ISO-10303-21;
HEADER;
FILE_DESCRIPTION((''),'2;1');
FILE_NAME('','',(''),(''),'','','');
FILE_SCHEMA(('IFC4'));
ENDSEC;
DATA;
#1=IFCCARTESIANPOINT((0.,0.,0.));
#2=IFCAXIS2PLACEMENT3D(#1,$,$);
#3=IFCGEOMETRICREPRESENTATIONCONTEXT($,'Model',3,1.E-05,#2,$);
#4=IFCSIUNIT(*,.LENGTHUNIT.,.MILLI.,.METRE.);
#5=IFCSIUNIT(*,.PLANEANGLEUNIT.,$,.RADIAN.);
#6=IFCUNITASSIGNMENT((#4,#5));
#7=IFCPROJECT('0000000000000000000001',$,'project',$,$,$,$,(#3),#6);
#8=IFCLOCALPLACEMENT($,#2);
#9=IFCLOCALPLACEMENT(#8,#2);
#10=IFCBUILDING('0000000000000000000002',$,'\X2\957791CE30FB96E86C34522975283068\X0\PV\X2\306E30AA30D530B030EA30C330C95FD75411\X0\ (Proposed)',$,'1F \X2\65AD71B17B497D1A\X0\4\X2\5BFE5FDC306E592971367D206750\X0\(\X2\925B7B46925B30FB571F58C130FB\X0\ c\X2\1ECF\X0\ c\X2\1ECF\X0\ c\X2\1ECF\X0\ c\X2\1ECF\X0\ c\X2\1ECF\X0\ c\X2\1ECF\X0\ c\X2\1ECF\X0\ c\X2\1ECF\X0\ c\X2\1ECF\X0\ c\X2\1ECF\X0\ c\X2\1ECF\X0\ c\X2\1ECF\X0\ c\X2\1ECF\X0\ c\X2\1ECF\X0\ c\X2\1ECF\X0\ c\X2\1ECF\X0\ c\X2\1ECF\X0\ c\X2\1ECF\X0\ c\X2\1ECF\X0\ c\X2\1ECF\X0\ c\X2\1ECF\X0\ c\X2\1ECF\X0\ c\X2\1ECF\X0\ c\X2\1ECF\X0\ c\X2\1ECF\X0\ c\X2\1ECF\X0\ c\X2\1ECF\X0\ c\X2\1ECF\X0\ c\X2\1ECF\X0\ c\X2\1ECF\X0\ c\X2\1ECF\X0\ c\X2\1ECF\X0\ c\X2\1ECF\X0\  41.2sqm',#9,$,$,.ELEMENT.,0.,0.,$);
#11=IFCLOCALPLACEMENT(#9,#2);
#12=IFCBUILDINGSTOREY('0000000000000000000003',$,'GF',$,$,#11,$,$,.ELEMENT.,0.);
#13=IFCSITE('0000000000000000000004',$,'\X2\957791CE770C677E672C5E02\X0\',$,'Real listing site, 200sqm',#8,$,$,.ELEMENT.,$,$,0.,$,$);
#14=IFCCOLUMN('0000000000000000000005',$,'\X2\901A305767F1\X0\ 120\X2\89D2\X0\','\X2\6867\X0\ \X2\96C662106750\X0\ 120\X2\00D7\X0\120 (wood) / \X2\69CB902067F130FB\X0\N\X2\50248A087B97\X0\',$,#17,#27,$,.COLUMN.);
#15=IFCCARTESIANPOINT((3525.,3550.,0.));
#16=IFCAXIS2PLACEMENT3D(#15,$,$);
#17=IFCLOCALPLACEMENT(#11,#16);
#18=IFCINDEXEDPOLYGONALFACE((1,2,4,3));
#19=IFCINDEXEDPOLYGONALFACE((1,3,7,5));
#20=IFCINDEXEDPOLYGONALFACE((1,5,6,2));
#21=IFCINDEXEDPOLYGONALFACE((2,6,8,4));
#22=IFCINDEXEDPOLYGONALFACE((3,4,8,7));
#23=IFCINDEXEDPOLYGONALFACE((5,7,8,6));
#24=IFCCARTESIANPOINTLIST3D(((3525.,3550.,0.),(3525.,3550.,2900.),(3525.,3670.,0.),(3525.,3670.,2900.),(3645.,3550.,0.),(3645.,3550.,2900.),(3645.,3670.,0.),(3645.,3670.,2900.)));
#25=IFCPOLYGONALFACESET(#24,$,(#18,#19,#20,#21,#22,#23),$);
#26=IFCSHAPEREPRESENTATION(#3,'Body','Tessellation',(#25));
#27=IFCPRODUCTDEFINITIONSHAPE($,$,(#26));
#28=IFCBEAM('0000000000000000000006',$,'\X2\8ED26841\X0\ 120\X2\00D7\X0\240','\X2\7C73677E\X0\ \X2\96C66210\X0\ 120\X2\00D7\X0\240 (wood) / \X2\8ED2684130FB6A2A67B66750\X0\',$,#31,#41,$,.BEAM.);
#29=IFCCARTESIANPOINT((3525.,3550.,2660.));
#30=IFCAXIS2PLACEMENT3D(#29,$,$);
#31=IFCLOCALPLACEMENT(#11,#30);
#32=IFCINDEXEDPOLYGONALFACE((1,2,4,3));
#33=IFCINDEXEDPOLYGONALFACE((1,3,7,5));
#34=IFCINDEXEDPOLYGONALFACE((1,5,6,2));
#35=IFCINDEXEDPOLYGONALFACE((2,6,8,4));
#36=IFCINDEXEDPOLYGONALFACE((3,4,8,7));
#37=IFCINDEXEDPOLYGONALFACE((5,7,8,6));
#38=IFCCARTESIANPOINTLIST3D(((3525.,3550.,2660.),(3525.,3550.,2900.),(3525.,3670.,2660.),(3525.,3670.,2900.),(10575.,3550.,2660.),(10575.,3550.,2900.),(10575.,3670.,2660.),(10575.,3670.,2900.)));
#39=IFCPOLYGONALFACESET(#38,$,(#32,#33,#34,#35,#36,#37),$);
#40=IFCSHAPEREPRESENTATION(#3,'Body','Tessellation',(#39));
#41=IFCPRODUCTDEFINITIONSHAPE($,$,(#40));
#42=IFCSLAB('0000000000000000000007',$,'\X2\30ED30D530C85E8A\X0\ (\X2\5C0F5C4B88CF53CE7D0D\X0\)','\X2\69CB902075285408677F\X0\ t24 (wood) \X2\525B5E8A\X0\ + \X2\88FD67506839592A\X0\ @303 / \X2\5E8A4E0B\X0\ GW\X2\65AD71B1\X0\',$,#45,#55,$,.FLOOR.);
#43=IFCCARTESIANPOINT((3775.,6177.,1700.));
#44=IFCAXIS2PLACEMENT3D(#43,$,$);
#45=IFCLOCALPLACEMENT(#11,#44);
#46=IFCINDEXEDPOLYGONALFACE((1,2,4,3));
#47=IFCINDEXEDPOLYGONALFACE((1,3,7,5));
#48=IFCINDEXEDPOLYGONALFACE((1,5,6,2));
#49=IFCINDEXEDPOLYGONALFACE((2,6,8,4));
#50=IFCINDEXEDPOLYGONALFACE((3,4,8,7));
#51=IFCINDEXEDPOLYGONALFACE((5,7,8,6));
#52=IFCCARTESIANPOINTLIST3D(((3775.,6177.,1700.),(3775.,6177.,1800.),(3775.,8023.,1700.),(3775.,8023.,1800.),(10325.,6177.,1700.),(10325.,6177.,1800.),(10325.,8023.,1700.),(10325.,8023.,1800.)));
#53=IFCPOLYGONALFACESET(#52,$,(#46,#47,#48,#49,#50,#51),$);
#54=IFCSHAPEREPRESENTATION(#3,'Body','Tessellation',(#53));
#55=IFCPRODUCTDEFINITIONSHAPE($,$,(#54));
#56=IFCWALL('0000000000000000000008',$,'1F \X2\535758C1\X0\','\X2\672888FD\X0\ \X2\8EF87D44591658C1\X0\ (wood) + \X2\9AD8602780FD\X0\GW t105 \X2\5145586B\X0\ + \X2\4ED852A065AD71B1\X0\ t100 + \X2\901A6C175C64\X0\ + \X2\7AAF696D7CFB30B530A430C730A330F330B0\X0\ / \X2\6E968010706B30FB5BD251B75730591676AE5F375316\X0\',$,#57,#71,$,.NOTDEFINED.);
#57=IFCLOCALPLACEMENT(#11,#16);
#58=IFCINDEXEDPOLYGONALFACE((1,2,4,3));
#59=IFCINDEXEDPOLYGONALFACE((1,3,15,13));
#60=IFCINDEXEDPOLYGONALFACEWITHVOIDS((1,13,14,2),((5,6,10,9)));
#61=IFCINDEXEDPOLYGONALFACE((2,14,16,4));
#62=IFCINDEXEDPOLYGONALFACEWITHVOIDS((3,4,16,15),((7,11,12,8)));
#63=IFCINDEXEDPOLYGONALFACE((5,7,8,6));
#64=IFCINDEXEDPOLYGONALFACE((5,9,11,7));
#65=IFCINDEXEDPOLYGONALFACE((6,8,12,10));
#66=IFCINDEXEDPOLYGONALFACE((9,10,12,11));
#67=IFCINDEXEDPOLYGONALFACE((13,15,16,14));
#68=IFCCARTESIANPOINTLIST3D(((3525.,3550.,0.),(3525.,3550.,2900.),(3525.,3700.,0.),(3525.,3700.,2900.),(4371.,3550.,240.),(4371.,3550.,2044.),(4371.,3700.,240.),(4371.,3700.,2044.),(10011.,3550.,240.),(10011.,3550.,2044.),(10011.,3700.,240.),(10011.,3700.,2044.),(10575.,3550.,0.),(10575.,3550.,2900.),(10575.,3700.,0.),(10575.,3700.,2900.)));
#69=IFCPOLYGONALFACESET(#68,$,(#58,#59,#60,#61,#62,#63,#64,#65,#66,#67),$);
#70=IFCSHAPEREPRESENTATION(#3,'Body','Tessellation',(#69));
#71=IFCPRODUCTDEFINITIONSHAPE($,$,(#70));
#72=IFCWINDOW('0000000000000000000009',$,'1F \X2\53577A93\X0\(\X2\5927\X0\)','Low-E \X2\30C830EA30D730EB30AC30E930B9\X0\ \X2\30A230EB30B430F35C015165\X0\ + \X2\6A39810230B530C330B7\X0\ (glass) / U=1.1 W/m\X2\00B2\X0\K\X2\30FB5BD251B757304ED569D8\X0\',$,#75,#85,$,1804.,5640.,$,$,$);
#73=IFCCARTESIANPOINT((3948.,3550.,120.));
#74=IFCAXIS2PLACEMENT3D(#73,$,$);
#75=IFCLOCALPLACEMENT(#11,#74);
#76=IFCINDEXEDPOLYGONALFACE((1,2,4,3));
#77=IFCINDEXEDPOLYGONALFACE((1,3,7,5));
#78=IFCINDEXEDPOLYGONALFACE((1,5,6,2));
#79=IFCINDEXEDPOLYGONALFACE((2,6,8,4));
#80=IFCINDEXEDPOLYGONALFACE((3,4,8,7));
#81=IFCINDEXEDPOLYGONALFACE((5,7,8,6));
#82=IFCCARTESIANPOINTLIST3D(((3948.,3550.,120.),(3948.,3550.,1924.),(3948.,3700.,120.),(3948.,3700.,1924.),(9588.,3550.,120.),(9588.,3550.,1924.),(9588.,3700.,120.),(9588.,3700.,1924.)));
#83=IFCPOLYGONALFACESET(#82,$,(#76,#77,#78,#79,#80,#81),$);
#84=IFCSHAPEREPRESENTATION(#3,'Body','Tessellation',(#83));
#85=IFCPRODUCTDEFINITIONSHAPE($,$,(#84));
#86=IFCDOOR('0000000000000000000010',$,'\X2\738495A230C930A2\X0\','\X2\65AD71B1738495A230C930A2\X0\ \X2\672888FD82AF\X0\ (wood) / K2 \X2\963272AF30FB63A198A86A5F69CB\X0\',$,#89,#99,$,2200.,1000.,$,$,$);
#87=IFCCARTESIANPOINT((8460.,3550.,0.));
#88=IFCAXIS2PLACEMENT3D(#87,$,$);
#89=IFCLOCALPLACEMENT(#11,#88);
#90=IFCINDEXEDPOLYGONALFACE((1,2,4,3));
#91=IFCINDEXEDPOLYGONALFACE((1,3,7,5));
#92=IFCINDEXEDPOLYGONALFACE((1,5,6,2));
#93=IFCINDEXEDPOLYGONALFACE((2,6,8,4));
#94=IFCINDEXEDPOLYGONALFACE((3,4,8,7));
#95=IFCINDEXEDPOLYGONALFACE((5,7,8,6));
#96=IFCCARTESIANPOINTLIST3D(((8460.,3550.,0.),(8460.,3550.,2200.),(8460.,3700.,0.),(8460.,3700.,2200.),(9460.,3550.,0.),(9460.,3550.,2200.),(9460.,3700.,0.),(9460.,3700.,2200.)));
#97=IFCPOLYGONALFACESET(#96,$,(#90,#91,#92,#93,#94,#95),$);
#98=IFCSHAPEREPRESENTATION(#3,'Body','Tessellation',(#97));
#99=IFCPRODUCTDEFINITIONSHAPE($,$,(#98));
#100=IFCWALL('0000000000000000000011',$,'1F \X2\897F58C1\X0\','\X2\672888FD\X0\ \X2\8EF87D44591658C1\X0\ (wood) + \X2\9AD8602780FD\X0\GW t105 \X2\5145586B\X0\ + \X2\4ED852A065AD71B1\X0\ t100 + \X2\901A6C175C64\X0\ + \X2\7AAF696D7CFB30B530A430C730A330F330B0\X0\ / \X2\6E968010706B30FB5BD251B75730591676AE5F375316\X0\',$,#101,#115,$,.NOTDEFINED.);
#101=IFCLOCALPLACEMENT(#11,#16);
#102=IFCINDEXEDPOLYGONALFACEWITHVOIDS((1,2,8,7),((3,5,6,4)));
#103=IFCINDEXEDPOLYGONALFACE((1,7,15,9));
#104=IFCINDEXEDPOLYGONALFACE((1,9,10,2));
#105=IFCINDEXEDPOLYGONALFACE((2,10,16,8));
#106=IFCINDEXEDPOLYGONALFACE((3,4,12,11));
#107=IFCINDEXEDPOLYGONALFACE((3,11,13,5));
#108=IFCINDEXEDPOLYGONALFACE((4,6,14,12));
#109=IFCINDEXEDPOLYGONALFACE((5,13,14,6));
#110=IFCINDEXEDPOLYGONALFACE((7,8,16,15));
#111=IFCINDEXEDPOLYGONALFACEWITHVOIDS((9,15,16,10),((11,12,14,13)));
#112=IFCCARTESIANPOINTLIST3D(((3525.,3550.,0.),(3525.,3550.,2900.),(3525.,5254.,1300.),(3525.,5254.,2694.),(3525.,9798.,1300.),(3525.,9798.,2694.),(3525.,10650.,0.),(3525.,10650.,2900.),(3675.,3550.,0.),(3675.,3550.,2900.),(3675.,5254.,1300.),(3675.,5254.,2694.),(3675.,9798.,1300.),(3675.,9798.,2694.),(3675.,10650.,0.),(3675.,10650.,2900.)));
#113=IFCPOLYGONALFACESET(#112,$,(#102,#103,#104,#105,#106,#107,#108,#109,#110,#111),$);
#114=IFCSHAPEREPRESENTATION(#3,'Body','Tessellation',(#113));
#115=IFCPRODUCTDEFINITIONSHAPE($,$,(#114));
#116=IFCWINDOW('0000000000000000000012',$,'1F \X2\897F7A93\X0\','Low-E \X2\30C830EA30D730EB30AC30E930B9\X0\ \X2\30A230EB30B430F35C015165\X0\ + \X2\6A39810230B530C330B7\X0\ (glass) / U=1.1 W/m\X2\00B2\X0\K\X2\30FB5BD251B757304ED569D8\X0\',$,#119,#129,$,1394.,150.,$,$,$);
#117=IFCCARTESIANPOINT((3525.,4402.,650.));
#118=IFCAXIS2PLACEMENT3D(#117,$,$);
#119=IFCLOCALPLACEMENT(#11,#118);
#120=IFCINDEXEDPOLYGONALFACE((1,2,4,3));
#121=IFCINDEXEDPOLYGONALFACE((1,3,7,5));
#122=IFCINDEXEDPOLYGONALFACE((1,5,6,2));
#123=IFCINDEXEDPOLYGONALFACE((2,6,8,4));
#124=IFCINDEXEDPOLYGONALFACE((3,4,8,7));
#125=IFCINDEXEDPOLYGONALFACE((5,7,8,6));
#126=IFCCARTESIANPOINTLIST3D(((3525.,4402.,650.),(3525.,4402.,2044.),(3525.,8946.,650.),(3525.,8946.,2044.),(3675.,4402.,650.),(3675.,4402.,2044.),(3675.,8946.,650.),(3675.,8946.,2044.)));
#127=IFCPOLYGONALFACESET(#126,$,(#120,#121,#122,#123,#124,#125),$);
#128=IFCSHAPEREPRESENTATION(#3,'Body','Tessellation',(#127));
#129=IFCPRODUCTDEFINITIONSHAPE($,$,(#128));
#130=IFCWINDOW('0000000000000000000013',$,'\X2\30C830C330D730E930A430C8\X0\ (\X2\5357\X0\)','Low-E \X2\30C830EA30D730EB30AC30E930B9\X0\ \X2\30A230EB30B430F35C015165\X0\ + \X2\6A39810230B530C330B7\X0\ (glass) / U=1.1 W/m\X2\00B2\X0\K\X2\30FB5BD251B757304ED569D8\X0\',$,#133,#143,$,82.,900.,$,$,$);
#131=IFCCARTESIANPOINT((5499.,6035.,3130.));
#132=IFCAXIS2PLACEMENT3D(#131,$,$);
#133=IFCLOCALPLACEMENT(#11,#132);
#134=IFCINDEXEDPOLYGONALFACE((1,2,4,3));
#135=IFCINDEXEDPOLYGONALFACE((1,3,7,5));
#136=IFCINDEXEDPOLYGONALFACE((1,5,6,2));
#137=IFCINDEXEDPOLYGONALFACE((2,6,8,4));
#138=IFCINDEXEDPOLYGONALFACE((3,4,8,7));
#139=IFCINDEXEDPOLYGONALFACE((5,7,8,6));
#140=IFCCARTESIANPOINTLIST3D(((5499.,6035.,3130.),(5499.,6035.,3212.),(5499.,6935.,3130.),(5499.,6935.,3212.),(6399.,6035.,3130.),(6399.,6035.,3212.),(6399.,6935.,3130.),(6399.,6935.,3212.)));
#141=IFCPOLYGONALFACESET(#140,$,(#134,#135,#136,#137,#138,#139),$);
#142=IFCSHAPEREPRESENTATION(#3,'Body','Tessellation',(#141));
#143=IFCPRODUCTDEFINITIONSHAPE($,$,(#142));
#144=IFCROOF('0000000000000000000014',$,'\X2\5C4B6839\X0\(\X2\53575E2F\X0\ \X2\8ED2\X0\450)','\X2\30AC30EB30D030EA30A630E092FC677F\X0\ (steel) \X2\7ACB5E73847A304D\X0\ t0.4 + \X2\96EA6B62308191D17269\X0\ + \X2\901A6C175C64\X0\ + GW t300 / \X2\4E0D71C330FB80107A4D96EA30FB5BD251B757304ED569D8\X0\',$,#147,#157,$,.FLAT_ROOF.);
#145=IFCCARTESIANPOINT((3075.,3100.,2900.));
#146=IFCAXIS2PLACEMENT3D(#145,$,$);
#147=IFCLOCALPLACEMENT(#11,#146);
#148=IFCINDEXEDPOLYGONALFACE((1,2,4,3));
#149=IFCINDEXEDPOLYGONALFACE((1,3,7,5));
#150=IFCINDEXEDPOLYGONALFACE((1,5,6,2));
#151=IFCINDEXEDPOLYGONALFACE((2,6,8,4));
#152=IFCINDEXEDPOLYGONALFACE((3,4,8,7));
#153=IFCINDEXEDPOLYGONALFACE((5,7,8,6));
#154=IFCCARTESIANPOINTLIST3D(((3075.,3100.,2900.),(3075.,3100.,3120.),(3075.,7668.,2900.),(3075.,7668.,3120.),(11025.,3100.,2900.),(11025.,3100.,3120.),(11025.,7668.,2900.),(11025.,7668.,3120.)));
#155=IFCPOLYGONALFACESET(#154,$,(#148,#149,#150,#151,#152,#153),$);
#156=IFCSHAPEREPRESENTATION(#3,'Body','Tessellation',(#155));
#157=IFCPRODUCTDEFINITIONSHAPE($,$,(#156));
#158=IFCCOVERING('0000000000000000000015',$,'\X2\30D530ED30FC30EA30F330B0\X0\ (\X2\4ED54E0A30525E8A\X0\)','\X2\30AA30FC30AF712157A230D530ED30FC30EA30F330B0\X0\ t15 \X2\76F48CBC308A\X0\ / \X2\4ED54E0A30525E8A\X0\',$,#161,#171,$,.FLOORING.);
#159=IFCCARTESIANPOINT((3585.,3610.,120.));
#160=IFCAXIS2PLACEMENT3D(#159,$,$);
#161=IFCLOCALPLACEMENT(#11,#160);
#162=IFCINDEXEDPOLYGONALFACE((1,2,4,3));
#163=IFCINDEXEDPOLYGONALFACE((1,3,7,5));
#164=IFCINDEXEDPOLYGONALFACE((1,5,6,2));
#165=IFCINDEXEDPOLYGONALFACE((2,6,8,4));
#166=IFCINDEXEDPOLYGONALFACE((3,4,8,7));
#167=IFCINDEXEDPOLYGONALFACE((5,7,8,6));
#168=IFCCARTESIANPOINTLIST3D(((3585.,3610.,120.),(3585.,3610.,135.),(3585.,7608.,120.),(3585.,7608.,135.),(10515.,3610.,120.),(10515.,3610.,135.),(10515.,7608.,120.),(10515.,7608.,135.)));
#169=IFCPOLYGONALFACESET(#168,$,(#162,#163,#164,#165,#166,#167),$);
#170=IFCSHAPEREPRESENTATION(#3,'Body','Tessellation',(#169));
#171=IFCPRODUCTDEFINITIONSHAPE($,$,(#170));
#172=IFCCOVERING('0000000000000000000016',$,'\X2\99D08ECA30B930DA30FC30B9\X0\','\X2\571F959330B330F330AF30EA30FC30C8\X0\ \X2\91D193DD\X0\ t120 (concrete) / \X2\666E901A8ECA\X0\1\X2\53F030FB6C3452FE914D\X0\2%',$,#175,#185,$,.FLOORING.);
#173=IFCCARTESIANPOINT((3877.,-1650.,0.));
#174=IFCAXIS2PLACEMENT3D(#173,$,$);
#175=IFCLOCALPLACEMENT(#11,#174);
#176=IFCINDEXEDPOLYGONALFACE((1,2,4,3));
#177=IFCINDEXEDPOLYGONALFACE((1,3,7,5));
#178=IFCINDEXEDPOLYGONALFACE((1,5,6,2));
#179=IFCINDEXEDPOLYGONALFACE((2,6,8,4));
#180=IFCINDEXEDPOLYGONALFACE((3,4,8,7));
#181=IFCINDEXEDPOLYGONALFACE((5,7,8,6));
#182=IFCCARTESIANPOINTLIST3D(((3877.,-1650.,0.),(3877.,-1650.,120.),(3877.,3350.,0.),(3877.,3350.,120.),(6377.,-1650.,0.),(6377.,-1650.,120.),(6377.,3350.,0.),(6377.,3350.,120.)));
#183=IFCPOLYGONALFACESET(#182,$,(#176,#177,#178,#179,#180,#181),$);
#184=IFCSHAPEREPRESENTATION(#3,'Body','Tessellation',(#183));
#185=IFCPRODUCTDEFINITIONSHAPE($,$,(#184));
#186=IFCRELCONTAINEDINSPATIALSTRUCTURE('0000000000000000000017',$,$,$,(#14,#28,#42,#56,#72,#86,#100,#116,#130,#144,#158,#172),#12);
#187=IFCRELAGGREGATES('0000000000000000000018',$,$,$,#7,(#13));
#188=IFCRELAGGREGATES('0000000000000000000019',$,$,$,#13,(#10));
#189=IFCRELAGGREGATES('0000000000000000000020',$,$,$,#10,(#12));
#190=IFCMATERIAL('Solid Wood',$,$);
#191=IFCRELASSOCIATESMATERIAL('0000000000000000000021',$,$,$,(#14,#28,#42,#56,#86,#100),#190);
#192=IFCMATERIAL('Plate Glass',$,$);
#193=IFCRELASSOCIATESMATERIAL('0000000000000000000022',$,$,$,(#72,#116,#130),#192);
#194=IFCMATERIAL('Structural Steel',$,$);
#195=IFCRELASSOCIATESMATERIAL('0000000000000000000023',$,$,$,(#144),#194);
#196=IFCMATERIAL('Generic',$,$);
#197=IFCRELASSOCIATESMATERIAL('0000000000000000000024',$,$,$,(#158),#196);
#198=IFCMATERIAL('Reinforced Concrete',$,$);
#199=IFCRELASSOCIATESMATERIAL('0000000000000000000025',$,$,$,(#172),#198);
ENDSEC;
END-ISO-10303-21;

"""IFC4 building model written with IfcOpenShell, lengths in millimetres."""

from ifc_helpers import new_model, si_unit, frame, frame_2d, origin, place, context, project, spatial, rectangle, extrude, material, element, fill, save


model = new_model("IFC4")

# Units and contexts
model_context = context("Model", 3, precision=1e-05, world=origin())
ifc_project = project(units=[si_unit("LENGTHUNIT", "METRE", prefix="MILLI"), si_unit("PLANEANGLEUNIT", "RADIAN")], contexts=[model_context])

# Site, building, storey
site_placement = place(None, origin())
site = spatial("IfcSite", under=ifc_project, at=site_placement, Name="長野県松本市", ObjectType="Real listing site, 200sqm", CompositionType="ELEMENT", RefElevation=0.0)
building_placement = place(site_placement, origin())
building = spatial("IfcBuilding", under=site, at=building_placement, Name="長野・雨水利用とPVのオフグリッド志向 (Proposed)", ObjectType="1F 断熱等級4対応の天然素材(鉛筆鉛・土壁・ cỏ cỏ cỏ cỏ cỏ cỏ cỏ cỏ cỏ cỏ cỏ cỏ cỏ cỏ cỏ cỏ cỏ cỏ cỏ cỏ cỏ cỏ cỏ cỏ cỏ cỏ cỏ cỏ cỏ cỏ cỏ cỏ cỏ  41.2sqm", CompositionType="ELEMENT", ElevationOfRefHeight=0.0, ElevationOfTerrain=0.0)
storey_placement = place(building_placement, origin())
storey = spatial("IfcBuildingStorey", under=building, at=storey_placement, Name="GF", CompositionType="ELEMENT", Elevation=0.0)

# Column
ifc_material_1 = material(Name="Solid Wood")
column_1_placement = place(storey_placement, frame((3525.0, 3550.0, 0.0)))
element("IfcColumn", 1, at=column_1_placement, inside=storey, material=ifc_material_1, Name="通し柱 120角", Description="桧 集成材 120×120 (wood) / 構造柱・N値計算", PredefinedType="COLUMN", context=model_context, shape_type="SweptSolid", body=[
    extrude(rectangle(XDim=120.0, YDim=120.0, at=frame_2d((60.0, 60.0))), frame((3525.0, 3550.0, 0.0)), (0.0, 0.0, 1.0), 2900.0),
])

# Beam
beam_1_placement = place(storey_placement, frame((3525.0, 3550.0, 2660.0)))
element("IfcBeam", 2, at=beam_1_placement, inside=storey, material=ifc_material_1, Name="軒桁 120×240", Description="米松 集成 120×240 (wood) / 軒桁・横架材", PredefinedType="BEAM", context=model_context, shape_type="SweptSolid", body=[
    extrude(rectangle(XDim=7050.0, YDim=120.0, at=frame_2d((3525.0, 60.0))), frame((3525.0, 3550.0, 2660.0)), (0.0, 0.0, 1.0), 240.0),
])

# Slab
ifc_material_2 = material(Name="Reinforced Concrete")
slab_1_placement = place(storey_placement, frame((3775.0, 6177.0, 1700.0)))
element("IfcSlab", 3, at=slab_1_placement, inside=storey, material=ifc_material_1, Name="ロフト床 (小屋裏収納)", Description="構造用合板 t24 (wood) 剛床 + 製材根太 @303 / 床下 GW断熱", PredefinedType="FLOOR", context=model_context, shape_type="SweptSolid", body=[
    extrude(rectangle(XDim=6550.0, YDim=1846.0, at=frame_2d((3275.0, 923.0))), frame((3775.0, 6177.0, 1700.0)), (0.0, 0.0, 1.0), 100.0),
])

# Wall, openings, window, door
wall_1_placement = place(storey_placement, frame((3525.0, 3550.0, 0.0)))
wall_1 = element("IfcWall", 4, at=wall_1_placement, inside=storey, material=ifc_material_1, Name="1F 南壁", Description="木製 軸組外壁 (wood) + 高性能GW t105 充填 + 付加断熱 t100 + 通気層 + 窯業系サイディング / 準耐火・寒冷地外皮強化", PredefinedType="NOTDEFINED", context=model_context, shape_type="SweptSolid", body=[
    extrude(rectangle(XDim=7050.0, YDim=150.0, at=frame_2d((3525.0, 75.0))), frame((3525.0, 3550.0, 0.0)), (0.0, 0.0, 1.0), 2900.0),
])
opening_1_placement = place(storey_placement, frame((3948.0, 3550.0, 120.0)))
opening_1 = element("IfcOpeningElement", 5, at=opening_1_placement, cuts=wall_1, PredefinedType="NOTDEFINED", context=model_context, shape_type="SweptSolid", body=[
    extrude(rectangle(XDim=5640.0, YDim=150.0, at=frame_2d((2820.0, 75.0))), frame((3948.0, 3550.0, 120.0)), (0.0, 0.0, 1.0), 1804.0),
])
opening_2_placement = place(storey_placement, frame((8460.0, 3550.0, 0.0)))
opening_2 = element("IfcOpeningElement", 6, at=opening_2_placement, cuts=wall_1, PredefinedType="NOTDEFINED", context=model_context, shape_type="SweptSolid", body=[
    extrude(rectangle(XDim=1000.0, YDim=150.0, at=frame_2d((500.0, 75.0))), frame((8460.0, 3550.0, 0.0)), (0.0, 0.0, 1.0), 2200.0),
])
ifc_material_3 = material(Name="Plate Glass")
window_1_placement = place(storey_placement, frame((3948.0, 3550.0, 120.0)))
window_1 = element("IfcWindow", 7, at=window_1_placement, inside=storey, material=ifc_material_3, Name="1F 南窓(大)", Description="Low-E トリプルガラス アルゴン封入 + 樹脂サッシ (glass) / U=1.1 W/m²K・寒冷地仕様", OverallHeight=1804.0, OverallWidth=5640.0, context=model_context, shape_type="SweptSolid", body=[
    extrude(rectangle(XDim=5640.0, YDim=150.0, at=frame_2d((2820.0, 75.0))), frame((3948.0, 3550.0, 120.0)), (0.0, 0.0, 1.0), 1804.0),
])
fill(opening_1, window_1)
door_placement = place(storey_placement, frame((8460.0, 3550.0, 0.0)))
door = element("IfcDoor", 8, at=door_placement, inside=storey, material=ifc_material_1, Name="玄関ドア", Description="断熱玄関ドア 木製芯 (wood) / K2 防犯・採風機構", OverallHeight=2200.0, OverallWidth=1000.0, context=model_context, shape_type="SweptSolid", body=[
    extrude(rectangle(XDim=1000.0, YDim=150.0, at=frame_2d((500.0, 75.0))), frame((8460.0, 3550.0, 0.0)), (0.0, 0.0, 1.0), 2200.0),
])
fill(opening_2, door)

# Wall, opening, window
wall_2_placement = place(storey_placement, frame((3525.0, 3550.0, 0.0)))
wall_2 = element("IfcWall", 9, at=wall_2_placement, inside=storey, material=ifc_material_1, Name="1F 西壁", Description="木製 軸組外壁 (wood) + 高性能GW t105 充填 + 付加断熱 t100 + 通気層 + 窯業系サイディング / 準耐火・寒冷地外皮強化", PredefinedType="NOTDEFINED", context=model_context, shape_type="SweptSolid", body=[
    extrude(rectangle(XDim=150.0, YDim=7100.0, at=frame_2d((75.0, 3550.0))), frame((3525.0, 3550.0, 0.0)), (0.0, 0.0, 1.0), 2900.0),
])
opening_3_placement = place(storey_placement, frame((3525.0, 4402.0, 650.0)))
opening_3 = element("IfcOpeningElement", 10, at=opening_3_placement, cuts=wall_2, PredefinedType="NOTDEFINED", context=model_context, shape_type="SweptSolid", body=[
    extrude(rectangle(XDim=150.0, YDim=4544.0, at=frame_2d((75.0, 2272.0))), frame((3525.0, 4402.0, 650.0)), (0.0, 0.0, 1.0), 1394.0),
])
window_2_placement = place(storey_placement, frame((3525.0, 4402.0, 650.0)))
window_2 = element("IfcWindow", 11, at=window_2_placement, inside=storey, material=ifc_material_3, Name="1F 西窓", Description="Low-E トリプルガラス アルゴン封入 + 樹脂サッシ (glass) / U=1.1 W/m²K・寒冷地仕様", OverallHeight=1394.0, OverallWidth=150.0, context=model_context, shape_type="SweptSolid", body=[
    extrude(rectangle(XDim=150.0, YDim=4544.0, at=frame_2d((75.0, 2272.0))), frame((3525.0, 4402.0, 650.0)), (0.0, 0.0, 1.0), 1394.0),
])
fill(opening_3, window_2)

# Window
window_3_placement = place(storey_placement, frame((5499.0, 6035.0, 3130.0)))
element("IfcWindow", 12, at=window_3_placement, inside=storey, material=ifc_material_3, Name="トップライト (南)", Description="Low-E トリプルガラス アルゴン封入 + 樹脂サッシ (glass) / U=1.1 W/m²K・寒冷地仕様", OverallHeight=82.0, OverallWidth=900.0, context=model_context, shape_type="SweptSolid", body=[
    extrude(rectangle(XDim=900.0, YDim=900.0, at=frame_2d((450.0, 450.0))), frame((5499.0, 6035.0, 3130.0)), (0.0, 0.0, 1.0), 82.0),
])

# Roof
ifc_material_4 = material(Name="Structural Steel")
roof_placement = place(storey_placement, frame((3075.0, 3100.0, 2900.0)))
element("IfcRoof", 13, at=roof_placement, inside=storey, material=ifc_material_4, Name="屋根(南帯 軒450)", Description="ガルバリウム鋼板 (steel) 立平葺き t0.4 + 雪止め金物 + 通気層 + GW t300 / 不燃・耐積雪・寒冷地仕様", PredefinedType="FLAT_ROOF", context=model_context, shape_type="SweptSolid", body=[
    extrude(rectangle(XDim=7950.0, YDim=4568.0, at=frame_2d((3975.0, 2284.0))), frame((3075.0, 3100.0, 2900.0)), (0.0, 0.0, 1.0), 220.0),
])

# Coverings
ifc_material_5 = material(Name="Generic")
covering_1_placement = place(storey_placement, frame((3585.0, 3610.0, 120.0)))
element("IfcCovering", 14, at=covering_1_placement, inside=storey, material=ifc_material_5, Name="フローリング (仕上げ床)", Description="オーク無垢フローリング t15 直貼り / 仕上げ床", PredefinedType="FLOORING", context=model_context, shape_type="SweptSolid", body=[
    extrude(rectangle(XDim=6930.0, YDim=3998.0, at=frame_2d((3465.0, 1999.0))), frame((3585.0, 3610.0, 120.0)), (0.0, 0.0, 1.0), 15.0),
])
covering_2_placement = place(storey_placement, frame((3877.0, -1650.0, 0.0)))
element("IfcCovering", 15, at=covering_2_placement, inside=storey, material=ifc_material_2, Name="駐車スペース", Description="土間コンクリート 金鏝 t120 (concrete) / 普通車1台・水勾配2%", PredefinedType="FLOORING", context=model_context, shape_type="SweptSolid", body=[
    extrude(rectangle(XDim=2500.0, YDim=5000.0, at=frame_2d((1250.0, 2500.0))), frame((3877.0, -1650.0, 0.0)), (0.0, 0.0, 1.0), 120.0),
])

save(model, "model.ifc")
